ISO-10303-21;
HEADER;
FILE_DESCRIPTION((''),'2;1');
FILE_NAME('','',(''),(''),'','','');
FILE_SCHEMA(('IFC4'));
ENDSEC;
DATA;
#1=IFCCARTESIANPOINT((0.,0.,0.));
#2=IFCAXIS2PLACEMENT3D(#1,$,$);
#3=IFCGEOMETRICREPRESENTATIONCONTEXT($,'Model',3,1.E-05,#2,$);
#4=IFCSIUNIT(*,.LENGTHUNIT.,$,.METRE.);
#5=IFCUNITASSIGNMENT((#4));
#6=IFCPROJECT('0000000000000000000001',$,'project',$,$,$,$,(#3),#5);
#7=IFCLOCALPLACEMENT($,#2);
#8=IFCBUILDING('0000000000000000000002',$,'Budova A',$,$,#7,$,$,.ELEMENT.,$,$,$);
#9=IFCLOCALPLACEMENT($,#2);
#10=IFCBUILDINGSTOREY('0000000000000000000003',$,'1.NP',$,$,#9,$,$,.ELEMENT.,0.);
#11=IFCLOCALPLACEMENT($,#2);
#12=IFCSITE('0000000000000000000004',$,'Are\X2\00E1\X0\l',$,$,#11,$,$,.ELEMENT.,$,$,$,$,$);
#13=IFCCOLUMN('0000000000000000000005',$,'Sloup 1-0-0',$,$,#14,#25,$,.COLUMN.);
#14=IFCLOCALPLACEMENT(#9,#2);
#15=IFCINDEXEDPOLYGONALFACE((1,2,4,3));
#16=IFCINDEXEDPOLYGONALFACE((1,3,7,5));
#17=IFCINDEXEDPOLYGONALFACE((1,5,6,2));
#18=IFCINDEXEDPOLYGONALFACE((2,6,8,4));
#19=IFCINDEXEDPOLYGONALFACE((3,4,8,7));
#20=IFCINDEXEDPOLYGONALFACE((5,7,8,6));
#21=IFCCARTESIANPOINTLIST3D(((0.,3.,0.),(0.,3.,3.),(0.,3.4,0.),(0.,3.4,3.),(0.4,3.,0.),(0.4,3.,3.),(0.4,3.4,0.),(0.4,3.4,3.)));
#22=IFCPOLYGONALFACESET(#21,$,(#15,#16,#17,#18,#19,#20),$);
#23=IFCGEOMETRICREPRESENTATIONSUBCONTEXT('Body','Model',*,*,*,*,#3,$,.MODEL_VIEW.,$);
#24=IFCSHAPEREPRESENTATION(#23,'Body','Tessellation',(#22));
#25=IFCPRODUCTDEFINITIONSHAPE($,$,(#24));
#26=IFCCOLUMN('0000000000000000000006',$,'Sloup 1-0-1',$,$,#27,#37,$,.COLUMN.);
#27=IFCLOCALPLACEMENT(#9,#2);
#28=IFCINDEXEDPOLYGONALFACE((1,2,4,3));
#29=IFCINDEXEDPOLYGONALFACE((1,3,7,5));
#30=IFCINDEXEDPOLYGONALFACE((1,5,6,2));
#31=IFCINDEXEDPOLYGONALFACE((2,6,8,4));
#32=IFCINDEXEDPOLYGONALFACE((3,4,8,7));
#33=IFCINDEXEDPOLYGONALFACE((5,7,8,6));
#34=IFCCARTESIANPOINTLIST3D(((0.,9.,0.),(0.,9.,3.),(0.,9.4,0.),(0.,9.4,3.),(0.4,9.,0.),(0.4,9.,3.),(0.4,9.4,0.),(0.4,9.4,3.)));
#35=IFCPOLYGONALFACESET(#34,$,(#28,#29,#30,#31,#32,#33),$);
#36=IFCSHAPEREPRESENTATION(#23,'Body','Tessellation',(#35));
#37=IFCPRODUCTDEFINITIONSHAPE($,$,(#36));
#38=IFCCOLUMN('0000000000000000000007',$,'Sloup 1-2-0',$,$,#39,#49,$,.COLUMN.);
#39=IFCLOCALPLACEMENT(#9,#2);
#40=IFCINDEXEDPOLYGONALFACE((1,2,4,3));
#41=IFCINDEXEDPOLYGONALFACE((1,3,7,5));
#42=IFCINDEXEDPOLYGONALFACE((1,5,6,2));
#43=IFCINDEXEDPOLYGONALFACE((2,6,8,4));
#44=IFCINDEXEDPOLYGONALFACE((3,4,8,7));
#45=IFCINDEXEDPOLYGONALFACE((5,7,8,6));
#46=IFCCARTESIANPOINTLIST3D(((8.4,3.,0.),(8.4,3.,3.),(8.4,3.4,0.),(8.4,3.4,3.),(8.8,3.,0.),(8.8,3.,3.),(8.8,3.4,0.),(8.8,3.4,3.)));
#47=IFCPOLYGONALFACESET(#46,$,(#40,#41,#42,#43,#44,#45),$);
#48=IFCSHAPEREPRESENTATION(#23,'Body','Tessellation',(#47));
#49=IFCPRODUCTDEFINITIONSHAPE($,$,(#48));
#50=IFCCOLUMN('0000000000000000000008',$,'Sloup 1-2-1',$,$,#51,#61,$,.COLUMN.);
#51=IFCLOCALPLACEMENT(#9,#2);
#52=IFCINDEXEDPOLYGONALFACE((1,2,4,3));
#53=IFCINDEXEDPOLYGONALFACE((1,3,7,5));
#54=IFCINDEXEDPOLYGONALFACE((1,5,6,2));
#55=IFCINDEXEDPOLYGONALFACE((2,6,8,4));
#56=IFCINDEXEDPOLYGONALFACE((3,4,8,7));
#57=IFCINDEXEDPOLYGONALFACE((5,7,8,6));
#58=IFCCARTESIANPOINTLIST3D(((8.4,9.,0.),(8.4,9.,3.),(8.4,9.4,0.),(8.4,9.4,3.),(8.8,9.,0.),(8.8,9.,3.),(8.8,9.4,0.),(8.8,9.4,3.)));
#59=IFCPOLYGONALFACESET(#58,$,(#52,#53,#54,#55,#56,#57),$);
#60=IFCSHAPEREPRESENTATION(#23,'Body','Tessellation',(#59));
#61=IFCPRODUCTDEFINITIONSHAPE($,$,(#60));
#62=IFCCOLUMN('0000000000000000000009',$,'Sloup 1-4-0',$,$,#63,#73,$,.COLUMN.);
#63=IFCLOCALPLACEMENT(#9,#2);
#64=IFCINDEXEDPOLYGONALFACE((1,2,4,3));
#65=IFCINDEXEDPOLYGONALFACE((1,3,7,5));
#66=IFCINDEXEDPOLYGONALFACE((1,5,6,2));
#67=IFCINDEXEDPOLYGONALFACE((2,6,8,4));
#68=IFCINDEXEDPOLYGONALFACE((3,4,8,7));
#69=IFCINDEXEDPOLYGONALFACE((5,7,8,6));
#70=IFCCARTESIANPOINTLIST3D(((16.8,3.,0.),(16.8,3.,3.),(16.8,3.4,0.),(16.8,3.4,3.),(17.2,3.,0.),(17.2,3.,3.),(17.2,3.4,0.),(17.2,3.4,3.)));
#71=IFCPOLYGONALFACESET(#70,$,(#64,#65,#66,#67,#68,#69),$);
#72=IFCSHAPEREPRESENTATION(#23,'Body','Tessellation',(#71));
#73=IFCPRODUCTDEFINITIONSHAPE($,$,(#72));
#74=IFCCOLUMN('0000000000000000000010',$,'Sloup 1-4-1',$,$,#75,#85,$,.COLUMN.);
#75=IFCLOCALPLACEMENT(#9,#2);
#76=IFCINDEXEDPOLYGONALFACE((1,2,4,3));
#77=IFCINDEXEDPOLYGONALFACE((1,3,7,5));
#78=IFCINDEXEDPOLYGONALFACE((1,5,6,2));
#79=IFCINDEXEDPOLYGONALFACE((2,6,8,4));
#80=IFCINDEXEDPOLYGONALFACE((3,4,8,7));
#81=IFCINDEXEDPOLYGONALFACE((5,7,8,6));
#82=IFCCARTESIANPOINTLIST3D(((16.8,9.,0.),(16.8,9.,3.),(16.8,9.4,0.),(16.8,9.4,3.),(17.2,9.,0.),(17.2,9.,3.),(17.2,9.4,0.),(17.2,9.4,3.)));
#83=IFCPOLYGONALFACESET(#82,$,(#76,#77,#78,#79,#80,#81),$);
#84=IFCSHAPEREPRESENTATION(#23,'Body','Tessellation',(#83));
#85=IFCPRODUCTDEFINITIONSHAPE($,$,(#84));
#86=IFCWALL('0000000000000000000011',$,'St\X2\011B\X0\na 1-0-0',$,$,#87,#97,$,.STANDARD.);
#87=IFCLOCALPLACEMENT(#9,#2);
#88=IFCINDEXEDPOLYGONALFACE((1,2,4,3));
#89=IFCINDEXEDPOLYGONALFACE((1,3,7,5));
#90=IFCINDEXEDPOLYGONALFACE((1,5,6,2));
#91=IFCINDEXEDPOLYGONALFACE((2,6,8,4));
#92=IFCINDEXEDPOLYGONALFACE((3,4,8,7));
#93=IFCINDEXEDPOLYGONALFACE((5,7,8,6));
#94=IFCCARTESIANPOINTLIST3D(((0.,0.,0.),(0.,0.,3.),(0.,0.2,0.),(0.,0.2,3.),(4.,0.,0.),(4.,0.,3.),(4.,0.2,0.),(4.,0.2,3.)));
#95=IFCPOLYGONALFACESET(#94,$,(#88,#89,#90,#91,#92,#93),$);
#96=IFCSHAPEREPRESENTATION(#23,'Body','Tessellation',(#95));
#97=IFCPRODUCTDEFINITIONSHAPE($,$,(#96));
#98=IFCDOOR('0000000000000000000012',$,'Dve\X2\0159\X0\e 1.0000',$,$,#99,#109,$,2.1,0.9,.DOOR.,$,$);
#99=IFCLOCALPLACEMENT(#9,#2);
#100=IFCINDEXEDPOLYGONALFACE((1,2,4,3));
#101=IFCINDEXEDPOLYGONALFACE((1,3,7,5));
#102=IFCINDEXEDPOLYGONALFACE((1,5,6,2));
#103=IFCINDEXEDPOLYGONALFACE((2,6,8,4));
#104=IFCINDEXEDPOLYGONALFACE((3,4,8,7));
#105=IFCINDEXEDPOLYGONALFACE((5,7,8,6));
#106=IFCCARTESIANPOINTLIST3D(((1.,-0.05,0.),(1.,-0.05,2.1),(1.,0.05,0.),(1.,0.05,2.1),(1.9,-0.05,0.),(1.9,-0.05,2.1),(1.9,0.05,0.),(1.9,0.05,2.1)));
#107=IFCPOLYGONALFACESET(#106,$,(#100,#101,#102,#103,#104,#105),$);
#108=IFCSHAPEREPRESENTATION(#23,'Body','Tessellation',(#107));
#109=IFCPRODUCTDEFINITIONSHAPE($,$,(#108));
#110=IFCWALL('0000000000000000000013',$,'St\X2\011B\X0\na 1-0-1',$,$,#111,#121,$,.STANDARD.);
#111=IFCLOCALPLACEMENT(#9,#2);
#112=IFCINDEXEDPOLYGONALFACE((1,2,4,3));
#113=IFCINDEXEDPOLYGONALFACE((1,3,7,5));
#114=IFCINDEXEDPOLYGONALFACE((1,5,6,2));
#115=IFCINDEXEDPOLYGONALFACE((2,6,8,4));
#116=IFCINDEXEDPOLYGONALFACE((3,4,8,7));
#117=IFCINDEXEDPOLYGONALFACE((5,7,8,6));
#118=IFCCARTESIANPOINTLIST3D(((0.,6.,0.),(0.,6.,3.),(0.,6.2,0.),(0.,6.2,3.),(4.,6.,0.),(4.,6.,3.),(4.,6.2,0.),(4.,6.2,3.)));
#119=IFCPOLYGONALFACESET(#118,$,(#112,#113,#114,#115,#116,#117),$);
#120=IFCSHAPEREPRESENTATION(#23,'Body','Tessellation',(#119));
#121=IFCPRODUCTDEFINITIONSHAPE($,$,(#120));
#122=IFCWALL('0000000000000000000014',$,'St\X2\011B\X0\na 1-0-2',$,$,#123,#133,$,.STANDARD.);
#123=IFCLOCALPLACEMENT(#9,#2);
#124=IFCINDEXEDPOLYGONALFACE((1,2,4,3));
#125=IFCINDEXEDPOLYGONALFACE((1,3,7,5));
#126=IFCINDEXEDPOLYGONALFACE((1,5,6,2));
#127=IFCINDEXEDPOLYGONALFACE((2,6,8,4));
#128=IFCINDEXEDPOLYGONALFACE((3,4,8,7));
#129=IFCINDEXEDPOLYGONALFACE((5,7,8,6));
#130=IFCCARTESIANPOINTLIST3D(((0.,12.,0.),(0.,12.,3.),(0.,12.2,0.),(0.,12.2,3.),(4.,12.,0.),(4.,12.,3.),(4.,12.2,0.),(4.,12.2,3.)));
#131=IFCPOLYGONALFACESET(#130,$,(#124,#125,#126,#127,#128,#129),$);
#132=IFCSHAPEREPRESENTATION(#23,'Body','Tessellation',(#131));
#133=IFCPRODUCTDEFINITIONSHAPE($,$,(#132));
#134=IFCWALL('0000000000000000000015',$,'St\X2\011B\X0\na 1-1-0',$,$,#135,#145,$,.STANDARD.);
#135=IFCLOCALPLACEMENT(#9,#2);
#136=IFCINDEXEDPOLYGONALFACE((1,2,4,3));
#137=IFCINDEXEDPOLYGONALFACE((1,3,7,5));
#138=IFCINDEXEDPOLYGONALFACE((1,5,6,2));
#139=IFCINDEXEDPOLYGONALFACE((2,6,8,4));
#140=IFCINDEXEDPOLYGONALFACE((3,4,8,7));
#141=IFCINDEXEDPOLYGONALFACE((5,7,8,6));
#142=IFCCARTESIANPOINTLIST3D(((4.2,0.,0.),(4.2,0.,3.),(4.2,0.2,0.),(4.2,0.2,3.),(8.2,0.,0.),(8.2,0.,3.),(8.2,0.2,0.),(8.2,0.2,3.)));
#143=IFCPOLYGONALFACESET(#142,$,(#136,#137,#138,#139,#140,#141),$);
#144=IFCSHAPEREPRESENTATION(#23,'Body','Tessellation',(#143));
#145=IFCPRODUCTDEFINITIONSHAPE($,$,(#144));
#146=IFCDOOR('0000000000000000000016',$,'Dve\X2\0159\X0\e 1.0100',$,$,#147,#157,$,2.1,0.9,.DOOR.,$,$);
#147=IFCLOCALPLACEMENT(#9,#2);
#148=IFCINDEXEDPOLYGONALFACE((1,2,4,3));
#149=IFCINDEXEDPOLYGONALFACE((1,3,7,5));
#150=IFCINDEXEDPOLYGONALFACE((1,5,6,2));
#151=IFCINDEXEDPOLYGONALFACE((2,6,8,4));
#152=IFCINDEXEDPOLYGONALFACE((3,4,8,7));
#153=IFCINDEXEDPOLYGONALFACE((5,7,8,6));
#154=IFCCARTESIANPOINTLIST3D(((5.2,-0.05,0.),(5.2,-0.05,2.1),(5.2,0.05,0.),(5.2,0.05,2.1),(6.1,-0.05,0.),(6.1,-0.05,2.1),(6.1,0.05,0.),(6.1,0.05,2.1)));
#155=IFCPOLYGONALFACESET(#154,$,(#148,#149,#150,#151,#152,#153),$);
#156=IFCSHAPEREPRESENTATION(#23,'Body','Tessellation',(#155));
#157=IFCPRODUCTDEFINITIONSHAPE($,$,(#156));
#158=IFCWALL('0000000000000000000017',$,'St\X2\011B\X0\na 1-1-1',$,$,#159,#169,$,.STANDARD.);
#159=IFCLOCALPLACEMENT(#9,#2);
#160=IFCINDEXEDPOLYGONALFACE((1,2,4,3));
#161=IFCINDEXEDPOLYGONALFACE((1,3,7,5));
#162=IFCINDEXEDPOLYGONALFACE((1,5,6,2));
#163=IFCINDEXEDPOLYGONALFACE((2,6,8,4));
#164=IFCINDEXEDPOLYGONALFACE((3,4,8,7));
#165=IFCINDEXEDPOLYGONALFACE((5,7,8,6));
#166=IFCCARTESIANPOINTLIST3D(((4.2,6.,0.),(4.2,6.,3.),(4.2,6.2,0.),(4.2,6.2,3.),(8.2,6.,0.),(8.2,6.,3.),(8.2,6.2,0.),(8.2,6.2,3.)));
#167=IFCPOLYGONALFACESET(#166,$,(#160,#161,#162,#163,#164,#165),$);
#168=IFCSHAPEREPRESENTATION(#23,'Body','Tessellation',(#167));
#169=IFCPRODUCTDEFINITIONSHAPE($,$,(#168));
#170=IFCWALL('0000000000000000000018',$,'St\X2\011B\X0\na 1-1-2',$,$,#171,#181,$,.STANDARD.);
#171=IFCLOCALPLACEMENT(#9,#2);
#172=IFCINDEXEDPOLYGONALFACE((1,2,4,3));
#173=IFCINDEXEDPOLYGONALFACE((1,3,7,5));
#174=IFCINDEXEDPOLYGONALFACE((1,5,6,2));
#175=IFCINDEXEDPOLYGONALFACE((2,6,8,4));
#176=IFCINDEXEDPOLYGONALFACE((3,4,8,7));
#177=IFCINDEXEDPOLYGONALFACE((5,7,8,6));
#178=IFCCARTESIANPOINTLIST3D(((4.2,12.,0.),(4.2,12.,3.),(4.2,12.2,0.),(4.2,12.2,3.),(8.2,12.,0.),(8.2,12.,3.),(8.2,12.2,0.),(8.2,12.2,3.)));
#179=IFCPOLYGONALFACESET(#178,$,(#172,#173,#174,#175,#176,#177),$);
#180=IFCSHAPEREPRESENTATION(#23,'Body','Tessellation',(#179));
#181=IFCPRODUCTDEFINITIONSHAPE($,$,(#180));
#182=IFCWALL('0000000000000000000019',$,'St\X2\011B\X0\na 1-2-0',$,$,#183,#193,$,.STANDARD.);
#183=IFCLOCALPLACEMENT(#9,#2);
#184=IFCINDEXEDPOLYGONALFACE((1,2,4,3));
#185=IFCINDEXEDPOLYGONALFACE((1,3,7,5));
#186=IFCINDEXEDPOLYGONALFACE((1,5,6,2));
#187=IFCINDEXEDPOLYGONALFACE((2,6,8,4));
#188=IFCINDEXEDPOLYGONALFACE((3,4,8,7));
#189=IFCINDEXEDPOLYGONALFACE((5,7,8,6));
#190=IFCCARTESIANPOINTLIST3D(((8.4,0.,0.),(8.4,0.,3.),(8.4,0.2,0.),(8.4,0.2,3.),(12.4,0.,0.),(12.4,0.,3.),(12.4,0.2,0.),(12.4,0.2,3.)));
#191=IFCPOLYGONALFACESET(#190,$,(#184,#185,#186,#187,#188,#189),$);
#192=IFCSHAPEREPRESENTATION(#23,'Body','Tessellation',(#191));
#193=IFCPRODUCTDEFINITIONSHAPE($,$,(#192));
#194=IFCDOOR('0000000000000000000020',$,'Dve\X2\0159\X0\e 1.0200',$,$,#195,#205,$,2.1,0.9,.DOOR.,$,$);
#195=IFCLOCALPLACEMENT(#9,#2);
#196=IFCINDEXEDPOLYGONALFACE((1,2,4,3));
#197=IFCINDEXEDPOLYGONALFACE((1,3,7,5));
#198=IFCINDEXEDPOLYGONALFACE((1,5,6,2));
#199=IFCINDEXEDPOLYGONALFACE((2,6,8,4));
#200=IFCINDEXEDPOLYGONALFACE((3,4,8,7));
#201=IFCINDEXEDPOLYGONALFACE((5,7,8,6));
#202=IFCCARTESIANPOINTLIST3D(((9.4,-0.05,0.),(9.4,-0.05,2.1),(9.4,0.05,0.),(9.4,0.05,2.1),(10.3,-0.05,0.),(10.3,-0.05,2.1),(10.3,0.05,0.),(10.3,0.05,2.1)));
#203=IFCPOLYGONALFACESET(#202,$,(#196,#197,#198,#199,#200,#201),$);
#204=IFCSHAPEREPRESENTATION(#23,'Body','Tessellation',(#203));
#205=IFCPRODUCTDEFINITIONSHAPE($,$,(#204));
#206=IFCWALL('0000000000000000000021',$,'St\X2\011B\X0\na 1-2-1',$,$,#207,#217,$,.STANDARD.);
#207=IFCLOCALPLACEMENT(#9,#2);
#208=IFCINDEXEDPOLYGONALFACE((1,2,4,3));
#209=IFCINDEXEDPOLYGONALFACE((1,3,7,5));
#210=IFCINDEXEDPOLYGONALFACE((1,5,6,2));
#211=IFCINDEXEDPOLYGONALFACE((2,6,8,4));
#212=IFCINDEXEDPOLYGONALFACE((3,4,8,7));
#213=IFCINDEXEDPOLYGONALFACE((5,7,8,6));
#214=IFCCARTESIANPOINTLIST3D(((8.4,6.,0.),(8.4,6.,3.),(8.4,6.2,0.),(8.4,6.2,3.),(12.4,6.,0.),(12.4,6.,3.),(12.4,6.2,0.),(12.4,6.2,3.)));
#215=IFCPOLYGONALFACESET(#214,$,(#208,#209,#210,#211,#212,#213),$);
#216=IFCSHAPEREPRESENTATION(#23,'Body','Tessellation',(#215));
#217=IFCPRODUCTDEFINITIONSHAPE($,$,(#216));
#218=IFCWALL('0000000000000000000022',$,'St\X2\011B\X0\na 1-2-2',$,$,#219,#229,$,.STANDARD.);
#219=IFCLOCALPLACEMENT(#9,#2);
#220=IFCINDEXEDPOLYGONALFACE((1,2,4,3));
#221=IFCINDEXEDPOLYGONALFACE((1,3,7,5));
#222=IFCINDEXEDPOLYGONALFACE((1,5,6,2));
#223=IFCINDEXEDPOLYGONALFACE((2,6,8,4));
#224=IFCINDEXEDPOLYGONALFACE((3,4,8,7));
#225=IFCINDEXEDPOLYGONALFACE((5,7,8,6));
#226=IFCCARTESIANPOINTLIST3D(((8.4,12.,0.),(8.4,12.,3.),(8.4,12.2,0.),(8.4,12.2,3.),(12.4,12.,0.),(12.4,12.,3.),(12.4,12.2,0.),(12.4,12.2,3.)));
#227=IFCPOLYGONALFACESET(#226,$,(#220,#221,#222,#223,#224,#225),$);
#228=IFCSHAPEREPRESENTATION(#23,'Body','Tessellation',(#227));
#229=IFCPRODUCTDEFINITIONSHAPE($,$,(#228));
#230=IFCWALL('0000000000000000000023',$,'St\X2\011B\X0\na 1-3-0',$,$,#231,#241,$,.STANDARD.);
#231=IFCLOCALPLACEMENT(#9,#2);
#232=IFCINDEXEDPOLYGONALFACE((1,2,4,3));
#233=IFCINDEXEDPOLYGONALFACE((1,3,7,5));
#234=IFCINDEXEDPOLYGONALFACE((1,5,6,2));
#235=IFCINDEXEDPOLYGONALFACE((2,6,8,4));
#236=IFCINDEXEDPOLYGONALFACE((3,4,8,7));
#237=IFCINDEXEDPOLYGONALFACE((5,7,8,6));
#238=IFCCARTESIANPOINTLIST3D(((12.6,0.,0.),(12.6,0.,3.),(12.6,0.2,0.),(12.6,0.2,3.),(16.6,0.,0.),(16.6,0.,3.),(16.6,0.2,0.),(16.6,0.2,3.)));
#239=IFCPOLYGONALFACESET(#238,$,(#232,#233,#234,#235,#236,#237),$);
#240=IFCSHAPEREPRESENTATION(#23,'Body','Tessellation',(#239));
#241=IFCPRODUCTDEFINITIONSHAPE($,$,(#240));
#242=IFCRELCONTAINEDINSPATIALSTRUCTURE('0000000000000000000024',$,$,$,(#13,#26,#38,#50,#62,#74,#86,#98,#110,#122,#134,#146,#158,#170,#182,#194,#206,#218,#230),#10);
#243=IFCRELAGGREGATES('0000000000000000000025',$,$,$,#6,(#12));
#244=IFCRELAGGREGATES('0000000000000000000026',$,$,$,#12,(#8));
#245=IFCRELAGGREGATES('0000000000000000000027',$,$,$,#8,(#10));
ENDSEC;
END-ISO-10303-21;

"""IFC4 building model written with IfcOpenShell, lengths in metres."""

from ifc_helpers import new_model, si_unit, frame, frame_2d, origin, place, context, subcontext, project, spatial, rectangle, extrude, element, save


model = new_model("IFC4")

# Units and contexts
model_context = context("Model", 3, precision=1e-05, world=origin())
body_context = subcontext(model_context, "Body", "Model", "MODEL_VIEW")
ifc_project = project(units=[si_unit("LENGTHUNIT", "METRE")], contexts=[model_context])

# Site, building, storey
site_placement = place(None, origin())
site = spatial("IfcSite", under=ifc_project, at=site_placement, Name="Areál", CompositionType="ELEMENT")
building_placement = place(None, origin())
building = spatial("IfcBuilding", under=site, at=building_placement, Name="Budova A", CompositionType="ELEMENT")
storey_placement = place(None, origin())
storey = spatial("IfcBuildingStorey", under=building, at=storey_placement, Name="1.NP", CompositionType="ELEMENT", Elevation=0.0)

# Columns
for number, where, name in (
    (1, (0.0, 3.0, 0.0), "Sloup 1-0-0"),
    (2, (0.0, 9.0, 0.0), "Sloup 1-0-1"),
    (3, (8.4, 3.0, 0.0), "Sloup 1-2-0"),
    (4, (8.4, 9.0, 0.0), "Sloup 1-2-1"),
    (5, (16.8, 3.0, 0.0), "Sloup 1-4-0"),
    (6, (16.8, 9.0, 0.0), "Sloup 1-4-1"),
):
    element("IfcColumn", number, at=place(storey_placement, frame(where)), inside=storey, Name=name, PredefinedType="COLUMN", context=body_context, shape_type="SweptSolid", body=[
        extrude(rectangle(XDim=0.4, YDim=0.4, at=frame_2d((0.2, 0.2))), origin(), (0.0, 0.0, 1.0), 3.0),
    ])

# Wall
wall_1_placement = place(storey_placement, origin())
element("IfcWall", 7, at=wall_1_placement, inside=storey, Name="Stěna 1-0-0", PredefinedType="STANDARD", context=body_context, shape_type="SweptSolid", body=[
    extrude(rectangle(XDim=4.0, YDim=0.2, at=frame_2d((2.0, 0.1))), origin(), (0.0, 0.0, 1.0), 3.0),
])

# Door
door_1_placement = place(storey_placement, frame((1.0, -0.05, 0.0)))
element("IfcDoor", 8, at=door_1_placement, inside=storey, Name="Dveře 1.0000", OverallHeight=2.1, OverallWidth=0.9, PredefinedType="DOOR", context=body_context, shape_type="SweptSolid", body=[
    extrude(rectangle(XDim=0.9, YDim=0.1, at=frame_2d((0.45, 0.05))), origin(), (0.0, 0.0, 1.0), 2.1),
])

# Walls
for number, where, name in (
    (9, (0.0, 6.0, 0.0), "Stěna 1-0-1"),
    (10, (0.0, 12.0, 0.0), "Stěna 1-0-2"),
    (11, (4.2, 0.0, 0.0), "Stěna 1-1-0"),
):
    element("IfcWall", number, at=place(storey_placement, frame(where)), inside=storey, Name=name, PredefinedType="STANDARD", context=body_context, shape_type="SweptSolid", body=[
        extrude(rectangle(XDim=4.0, YDim=0.2, at=frame_2d((2.0, 0.1))), origin(), (0.0, 0.0, 1.0), 3.0),
    ])

# Door
door_2_placement = place(storey_placement, frame((5.2, -0.05, 0.0)))
element("IfcDoor", 12, at=door_2_placement, inside=storey, Name="Dveře 1.0100", OverallHeight=2.1, OverallWidth=0.9, PredefinedType="DOOR", context=body_context, shape_type="SweptSolid", body=[
    extrude(rectangle(XDim=0.9, YDim=0.1, at=frame_2d((0.45, 0.05))), origin(), (0.0, 0.0, 1.0), 2.1),
])

# Walls
for number, where, name in (
    (13, (4.2, 6.0, 0.0), "Stěna 1-1-1"),
    (14, (4.2, 12.0, 0.0), "Stěna 1-1-2"),
    (15, (8.4, 0.0, 0.0), "Stěna 1-2-0"),
):
    element("IfcWall", number, at=place(storey_placement, frame(where)), inside=storey, Name=name, PredefinedType="STANDARD", context=body_context, shape_type="SweptSolid", body=[
        extrude(rectangle(XDim=4.0, YDim=0.2, at=frame_2d((2.0, 0.1))), origin(), (0.0, 0.0, 1.0), 3.0),
    ])

# Door
door_3_placement = place(storey_placement, frame((9.4, -0.05, 0.0)))
element("IfcDoor", 16, at=door_3_placement, inside=storey, Name="Dveře 1.0200", OverallHeight=2.1, OverallWidth=0.9, PredefinedType="DOOR", context=body_context, shape_type="SweptSolid", body=[
    extrude(rectangle(XDim=0.9, YDim=0.1, at=frame_2d((0.45, 0.05))), origin(), (0.0, 0.0, 1.0), 2.1),
])

# Walls
for number, where, name in (
    (17, (8.4, 6.0, 0.0), "Stěna 1-2-1"),
    (18, (8.4, 12.0, 0.0), "Stěna 1-2-2"),
    (19, (12.6, 0.0, 0.0), "Stěna 1-3-0"),
):
    element("IfcWall", number, at=place(storey_placement, frame(where)), inside=storey, Name=name, PredefinedType="STANDARD", context=body_context, shape_type="SweptSolid", body=[
        extrude(rectangle(XDim=4.0, YDim=0.2, at=frame_2d((2.0, 0.1))), origin(), (0.0, 0.0, 1.0), 3.0),
    ])

save(model, "model.ifc")
